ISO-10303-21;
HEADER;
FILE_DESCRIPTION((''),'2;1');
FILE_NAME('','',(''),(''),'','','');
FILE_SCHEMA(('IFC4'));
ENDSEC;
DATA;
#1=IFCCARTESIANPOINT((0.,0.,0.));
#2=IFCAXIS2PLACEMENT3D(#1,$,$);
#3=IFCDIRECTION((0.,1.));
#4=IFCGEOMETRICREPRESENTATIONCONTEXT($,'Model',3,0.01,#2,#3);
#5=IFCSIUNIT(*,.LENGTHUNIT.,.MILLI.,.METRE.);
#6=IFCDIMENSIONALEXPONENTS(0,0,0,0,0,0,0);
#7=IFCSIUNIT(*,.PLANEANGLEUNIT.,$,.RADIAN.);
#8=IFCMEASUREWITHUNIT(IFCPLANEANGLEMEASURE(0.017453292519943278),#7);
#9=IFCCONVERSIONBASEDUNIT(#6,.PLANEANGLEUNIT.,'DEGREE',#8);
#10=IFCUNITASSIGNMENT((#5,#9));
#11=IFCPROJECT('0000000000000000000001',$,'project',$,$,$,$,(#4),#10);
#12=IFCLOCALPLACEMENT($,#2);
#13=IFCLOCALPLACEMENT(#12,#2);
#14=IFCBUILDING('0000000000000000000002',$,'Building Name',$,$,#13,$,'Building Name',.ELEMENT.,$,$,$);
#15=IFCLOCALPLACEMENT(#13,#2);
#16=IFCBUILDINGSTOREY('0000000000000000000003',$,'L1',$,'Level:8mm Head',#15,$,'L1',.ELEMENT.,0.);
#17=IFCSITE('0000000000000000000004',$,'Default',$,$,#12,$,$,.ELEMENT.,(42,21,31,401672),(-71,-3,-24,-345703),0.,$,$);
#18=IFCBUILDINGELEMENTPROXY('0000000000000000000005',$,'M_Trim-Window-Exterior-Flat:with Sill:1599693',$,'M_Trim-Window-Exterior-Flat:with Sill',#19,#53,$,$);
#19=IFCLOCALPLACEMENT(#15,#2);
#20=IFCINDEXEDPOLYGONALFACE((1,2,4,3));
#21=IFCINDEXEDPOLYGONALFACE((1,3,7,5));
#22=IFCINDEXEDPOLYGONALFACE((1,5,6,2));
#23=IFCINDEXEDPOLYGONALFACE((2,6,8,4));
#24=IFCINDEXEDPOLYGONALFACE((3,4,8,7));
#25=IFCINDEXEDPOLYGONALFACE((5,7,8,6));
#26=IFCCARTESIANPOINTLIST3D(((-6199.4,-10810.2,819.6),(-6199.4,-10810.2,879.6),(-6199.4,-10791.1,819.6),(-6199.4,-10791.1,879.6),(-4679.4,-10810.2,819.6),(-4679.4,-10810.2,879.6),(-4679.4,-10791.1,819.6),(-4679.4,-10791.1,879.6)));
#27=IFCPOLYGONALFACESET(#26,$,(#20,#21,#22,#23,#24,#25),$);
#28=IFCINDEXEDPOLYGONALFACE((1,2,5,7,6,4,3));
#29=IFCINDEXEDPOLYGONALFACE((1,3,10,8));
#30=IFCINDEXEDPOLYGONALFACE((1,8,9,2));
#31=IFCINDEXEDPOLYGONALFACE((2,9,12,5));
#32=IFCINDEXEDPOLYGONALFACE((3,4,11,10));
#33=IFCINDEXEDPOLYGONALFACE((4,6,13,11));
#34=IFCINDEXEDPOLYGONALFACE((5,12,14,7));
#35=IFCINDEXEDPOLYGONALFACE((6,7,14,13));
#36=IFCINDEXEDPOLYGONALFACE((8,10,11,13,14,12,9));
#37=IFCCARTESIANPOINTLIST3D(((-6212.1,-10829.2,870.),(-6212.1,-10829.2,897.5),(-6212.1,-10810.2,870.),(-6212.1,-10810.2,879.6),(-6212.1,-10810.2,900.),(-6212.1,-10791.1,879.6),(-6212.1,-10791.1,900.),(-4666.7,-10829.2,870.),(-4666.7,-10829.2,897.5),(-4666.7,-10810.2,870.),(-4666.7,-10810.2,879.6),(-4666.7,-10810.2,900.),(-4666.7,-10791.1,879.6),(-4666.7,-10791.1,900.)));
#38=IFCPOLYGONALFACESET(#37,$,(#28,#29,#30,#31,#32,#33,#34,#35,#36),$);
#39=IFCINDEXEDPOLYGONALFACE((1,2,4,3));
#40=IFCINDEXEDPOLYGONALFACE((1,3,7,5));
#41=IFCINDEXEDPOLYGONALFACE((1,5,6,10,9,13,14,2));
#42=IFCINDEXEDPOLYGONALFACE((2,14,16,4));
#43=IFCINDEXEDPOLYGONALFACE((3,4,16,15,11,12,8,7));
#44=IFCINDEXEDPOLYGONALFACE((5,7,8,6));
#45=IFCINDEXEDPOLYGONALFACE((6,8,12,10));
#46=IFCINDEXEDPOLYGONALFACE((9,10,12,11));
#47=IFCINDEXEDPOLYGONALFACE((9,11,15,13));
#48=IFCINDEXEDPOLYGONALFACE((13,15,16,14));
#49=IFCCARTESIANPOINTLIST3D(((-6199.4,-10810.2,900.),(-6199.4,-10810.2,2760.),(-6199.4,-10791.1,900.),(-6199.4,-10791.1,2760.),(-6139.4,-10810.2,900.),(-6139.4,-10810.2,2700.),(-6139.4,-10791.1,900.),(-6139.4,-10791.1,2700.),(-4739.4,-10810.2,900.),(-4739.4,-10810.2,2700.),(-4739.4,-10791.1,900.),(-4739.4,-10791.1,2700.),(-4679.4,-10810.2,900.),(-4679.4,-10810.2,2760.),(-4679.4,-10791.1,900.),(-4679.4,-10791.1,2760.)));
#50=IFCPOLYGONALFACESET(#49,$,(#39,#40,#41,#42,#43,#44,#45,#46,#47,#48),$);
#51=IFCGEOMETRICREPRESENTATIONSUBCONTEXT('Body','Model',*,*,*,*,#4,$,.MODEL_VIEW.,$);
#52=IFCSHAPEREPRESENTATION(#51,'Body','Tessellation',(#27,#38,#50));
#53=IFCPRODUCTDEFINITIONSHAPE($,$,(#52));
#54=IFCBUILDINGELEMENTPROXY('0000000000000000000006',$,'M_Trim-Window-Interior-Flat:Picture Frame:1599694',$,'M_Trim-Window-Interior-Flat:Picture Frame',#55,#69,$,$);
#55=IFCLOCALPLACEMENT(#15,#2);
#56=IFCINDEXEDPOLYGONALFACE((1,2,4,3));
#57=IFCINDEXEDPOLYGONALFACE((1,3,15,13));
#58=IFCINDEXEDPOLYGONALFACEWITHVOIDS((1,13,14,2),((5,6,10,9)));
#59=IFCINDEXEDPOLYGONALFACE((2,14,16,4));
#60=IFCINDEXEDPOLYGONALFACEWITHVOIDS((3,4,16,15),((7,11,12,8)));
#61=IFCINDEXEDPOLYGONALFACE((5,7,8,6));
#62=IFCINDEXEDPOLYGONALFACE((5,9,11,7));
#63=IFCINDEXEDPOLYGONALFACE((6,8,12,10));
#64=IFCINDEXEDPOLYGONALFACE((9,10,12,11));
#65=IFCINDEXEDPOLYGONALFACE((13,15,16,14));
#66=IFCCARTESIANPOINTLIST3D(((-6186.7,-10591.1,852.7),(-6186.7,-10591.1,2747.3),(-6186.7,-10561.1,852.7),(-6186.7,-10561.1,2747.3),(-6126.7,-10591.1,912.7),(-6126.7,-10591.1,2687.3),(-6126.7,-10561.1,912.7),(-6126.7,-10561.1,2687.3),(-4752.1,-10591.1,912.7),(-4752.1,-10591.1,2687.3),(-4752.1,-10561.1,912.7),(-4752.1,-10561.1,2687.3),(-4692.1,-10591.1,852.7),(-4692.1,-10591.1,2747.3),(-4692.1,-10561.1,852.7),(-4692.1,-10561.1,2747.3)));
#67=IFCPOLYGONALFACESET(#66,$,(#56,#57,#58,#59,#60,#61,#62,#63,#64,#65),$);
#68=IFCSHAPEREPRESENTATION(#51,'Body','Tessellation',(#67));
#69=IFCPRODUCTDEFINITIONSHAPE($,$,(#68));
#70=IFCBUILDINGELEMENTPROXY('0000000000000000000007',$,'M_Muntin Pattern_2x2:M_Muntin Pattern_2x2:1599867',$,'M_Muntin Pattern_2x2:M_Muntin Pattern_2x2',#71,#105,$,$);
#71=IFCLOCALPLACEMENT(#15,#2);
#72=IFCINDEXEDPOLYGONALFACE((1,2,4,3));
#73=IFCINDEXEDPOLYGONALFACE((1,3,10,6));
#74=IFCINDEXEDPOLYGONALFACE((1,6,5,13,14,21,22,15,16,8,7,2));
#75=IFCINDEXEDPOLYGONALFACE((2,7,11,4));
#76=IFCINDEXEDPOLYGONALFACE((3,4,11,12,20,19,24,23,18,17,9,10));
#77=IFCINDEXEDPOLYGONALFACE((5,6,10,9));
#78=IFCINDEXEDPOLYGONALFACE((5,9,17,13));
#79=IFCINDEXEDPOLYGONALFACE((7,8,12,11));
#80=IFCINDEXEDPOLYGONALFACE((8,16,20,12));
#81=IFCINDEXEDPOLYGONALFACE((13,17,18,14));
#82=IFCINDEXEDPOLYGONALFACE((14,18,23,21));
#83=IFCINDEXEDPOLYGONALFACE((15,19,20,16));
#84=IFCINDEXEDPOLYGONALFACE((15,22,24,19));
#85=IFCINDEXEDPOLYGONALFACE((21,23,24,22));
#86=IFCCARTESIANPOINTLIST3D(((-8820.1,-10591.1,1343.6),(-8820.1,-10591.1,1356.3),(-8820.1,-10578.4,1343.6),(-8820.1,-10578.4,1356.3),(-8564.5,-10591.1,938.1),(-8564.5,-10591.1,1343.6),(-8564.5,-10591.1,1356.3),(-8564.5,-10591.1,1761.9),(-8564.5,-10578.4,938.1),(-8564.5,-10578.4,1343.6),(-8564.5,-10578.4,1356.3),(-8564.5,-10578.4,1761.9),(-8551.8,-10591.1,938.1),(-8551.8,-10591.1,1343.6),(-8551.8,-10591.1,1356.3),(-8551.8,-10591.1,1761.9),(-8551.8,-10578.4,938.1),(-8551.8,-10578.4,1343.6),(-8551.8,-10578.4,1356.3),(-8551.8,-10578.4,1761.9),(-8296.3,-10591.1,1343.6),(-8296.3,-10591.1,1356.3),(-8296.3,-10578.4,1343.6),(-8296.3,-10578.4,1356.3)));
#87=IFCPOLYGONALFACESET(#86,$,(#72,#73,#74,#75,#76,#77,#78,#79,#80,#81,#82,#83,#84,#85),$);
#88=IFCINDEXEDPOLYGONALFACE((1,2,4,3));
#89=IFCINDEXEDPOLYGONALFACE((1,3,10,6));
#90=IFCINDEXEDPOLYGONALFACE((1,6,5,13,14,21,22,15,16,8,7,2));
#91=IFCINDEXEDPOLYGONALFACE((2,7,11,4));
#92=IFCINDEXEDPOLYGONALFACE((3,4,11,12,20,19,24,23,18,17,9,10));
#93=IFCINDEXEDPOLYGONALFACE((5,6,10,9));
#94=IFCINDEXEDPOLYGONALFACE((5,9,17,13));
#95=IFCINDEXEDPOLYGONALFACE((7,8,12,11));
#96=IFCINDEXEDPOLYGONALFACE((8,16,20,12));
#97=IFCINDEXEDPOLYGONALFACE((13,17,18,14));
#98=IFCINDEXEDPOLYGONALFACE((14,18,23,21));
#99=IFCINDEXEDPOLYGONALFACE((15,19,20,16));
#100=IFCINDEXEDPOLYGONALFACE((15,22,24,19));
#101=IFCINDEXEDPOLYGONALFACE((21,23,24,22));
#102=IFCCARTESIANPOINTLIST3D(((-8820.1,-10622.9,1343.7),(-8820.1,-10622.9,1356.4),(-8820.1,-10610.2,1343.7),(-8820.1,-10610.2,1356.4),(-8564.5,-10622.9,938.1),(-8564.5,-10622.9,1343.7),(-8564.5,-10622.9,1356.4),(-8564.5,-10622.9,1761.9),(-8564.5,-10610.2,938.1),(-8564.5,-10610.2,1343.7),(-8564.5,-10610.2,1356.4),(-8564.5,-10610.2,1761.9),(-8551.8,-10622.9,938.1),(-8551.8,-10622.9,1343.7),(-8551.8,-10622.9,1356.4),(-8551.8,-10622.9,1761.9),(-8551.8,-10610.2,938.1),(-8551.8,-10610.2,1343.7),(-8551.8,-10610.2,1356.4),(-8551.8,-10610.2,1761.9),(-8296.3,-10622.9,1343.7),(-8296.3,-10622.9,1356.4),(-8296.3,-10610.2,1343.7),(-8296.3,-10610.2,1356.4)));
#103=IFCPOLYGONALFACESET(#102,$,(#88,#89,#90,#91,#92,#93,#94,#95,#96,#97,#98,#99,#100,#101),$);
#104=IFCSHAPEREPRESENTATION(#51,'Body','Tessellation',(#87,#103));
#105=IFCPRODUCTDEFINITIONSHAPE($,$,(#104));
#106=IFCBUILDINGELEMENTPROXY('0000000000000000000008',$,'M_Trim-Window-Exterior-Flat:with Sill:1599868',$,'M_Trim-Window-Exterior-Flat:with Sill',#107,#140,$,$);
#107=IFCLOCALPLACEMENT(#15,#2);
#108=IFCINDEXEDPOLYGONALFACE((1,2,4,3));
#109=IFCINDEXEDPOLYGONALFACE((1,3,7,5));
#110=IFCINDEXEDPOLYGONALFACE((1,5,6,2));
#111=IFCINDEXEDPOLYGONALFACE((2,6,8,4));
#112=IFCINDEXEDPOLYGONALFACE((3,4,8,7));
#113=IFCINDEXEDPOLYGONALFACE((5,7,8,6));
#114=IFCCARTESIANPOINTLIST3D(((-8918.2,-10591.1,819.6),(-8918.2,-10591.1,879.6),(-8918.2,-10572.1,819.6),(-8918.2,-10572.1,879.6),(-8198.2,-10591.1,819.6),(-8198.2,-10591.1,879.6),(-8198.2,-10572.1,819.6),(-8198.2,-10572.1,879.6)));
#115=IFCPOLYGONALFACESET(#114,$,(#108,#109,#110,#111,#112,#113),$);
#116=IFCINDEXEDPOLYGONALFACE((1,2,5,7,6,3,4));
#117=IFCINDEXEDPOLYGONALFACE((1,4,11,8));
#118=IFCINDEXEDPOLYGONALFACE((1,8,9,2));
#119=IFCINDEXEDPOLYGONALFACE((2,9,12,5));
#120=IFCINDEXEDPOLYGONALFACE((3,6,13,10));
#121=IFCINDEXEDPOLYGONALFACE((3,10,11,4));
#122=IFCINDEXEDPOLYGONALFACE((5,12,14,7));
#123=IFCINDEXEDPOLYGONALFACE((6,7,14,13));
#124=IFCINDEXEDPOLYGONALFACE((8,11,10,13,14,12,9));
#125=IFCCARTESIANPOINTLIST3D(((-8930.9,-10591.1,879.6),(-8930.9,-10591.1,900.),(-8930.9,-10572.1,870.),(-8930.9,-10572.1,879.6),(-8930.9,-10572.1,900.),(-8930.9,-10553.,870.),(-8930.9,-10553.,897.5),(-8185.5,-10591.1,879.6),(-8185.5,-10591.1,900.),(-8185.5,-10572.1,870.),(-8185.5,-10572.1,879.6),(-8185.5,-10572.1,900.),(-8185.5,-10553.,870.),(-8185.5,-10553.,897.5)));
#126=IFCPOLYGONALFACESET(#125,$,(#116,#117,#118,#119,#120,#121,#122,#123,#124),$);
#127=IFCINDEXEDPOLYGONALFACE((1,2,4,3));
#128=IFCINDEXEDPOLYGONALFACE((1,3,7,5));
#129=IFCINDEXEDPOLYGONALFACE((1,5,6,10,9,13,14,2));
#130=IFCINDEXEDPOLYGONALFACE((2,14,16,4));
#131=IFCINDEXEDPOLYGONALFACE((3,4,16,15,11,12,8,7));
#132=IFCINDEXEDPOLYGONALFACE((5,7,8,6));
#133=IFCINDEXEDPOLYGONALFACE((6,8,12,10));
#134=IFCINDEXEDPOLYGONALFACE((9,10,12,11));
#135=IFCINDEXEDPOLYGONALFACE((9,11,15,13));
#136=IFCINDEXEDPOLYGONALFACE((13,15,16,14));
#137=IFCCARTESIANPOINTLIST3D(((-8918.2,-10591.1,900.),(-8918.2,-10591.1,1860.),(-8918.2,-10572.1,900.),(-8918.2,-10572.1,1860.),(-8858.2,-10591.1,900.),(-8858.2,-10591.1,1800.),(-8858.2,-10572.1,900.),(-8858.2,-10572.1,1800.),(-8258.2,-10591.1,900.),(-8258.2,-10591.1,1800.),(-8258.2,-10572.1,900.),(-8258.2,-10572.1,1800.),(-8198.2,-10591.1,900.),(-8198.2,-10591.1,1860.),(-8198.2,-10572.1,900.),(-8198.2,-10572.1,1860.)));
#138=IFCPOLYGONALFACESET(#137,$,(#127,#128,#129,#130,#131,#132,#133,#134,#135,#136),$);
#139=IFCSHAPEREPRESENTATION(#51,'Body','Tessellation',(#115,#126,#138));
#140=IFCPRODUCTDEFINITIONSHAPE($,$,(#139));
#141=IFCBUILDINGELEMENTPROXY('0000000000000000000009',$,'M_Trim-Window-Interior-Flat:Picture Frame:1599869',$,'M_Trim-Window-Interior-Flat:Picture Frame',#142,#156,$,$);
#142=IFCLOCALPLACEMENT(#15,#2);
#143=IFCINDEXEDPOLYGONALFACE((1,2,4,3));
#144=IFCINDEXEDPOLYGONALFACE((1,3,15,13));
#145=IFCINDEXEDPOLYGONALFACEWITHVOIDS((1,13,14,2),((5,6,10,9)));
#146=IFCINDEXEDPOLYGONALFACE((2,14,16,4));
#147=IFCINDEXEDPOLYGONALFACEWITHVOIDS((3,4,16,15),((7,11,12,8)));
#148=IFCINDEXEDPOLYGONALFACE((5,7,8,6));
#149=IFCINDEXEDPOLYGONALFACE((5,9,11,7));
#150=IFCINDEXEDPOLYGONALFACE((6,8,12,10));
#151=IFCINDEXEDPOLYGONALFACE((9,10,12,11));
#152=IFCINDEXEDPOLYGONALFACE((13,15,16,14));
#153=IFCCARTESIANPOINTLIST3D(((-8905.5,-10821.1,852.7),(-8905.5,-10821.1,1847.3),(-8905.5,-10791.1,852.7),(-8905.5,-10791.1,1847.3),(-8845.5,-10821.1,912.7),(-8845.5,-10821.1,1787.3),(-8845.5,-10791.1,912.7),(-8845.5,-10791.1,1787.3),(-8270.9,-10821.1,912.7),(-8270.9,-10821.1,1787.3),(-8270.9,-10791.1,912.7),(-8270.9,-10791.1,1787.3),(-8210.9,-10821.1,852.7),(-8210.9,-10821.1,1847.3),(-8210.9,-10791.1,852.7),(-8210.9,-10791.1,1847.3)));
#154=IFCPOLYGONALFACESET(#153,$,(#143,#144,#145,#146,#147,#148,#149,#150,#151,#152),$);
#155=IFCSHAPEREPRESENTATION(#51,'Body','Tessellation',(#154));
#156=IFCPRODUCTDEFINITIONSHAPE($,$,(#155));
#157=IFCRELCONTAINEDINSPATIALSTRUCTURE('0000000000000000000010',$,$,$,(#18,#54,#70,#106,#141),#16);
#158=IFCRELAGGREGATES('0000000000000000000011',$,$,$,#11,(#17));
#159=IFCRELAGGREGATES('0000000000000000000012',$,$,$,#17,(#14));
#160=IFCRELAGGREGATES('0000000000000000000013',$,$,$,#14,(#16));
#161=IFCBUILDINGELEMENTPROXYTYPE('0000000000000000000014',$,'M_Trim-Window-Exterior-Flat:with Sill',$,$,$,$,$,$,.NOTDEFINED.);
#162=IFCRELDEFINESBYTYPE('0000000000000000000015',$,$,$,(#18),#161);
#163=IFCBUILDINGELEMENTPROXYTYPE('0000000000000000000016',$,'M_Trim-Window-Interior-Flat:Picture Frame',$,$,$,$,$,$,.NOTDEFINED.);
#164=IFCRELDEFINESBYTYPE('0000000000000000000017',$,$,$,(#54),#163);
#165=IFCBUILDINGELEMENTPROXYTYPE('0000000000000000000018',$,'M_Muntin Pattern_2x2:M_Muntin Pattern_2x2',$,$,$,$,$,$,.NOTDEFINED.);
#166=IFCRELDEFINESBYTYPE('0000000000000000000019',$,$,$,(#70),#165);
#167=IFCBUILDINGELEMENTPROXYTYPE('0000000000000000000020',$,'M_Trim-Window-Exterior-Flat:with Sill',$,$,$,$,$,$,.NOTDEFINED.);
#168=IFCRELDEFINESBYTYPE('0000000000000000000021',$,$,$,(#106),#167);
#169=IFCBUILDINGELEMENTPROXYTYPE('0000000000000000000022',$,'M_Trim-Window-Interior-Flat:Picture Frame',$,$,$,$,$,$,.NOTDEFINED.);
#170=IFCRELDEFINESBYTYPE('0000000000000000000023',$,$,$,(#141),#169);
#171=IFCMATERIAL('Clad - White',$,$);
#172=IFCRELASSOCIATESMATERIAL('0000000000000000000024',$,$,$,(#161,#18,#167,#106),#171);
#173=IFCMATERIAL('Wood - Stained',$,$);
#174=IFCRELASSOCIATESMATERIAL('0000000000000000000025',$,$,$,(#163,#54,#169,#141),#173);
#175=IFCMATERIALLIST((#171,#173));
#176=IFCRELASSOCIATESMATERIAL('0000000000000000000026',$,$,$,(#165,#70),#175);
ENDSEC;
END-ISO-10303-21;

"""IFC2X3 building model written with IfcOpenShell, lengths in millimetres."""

from ifc_helpers import new_model, entity, si_unit, converted_unit, direction, frame, frame_2d, origin, place, context, subcontext, project, spatial, polyline, rectangle, outline, extrude, source, transform, mapped, material, material_list, type_object, type_shapes, element, save


model = new_model("IFC2X3")

# Units and contexts
model_context = context("Model", 3, precision=0.01, world=origin(), true_north=direction((0.0, 1.0)))
body_context = subcontext(model_context, "Body", "Model", "MODEL_VIEW")
ifc_project = project(units=[si_unit("LENGTHUNIT", "METRE", prefix="MILLI"), converted_unit("PLANEANGLEUNIT", "DEGREE", entity("IfcPlaneAngleMeasure", 0.017453292519943278), si_unit("PLANEANGLEUNIT", "RADIAN"), dimensions=[0, 0, 0, 0, 0, 0, 0])], contexts=[model_context])

# Site, building, storey
site_placement = place(None, origin())
site = spatial("IfcSite", under=ifc_project, at=site_placement, Name="Default", CompositionType="ELEMENT", RefLatitude=(42, 21, 31, 401672), RefLongitude=(-71, -3, -24, -345703), RefElevation=0.0)
building_placement = place(site_placement, origin())
building = spatial("IfcBuilding", under=site, at=building_placement, Name="Building Name", LongName="Building Name", CompositionType="ELEMENT")
storey_placement = place(building_placement, origin())
storey = spatial("IfcBuildingStorey", under=building, at=storey_placement, Name="L1", ObjectType="Level:8mm Head", LongName="L1", CompositionType="ELEMENT", Elevation=0.0)

# Building element proxies
ifc_material_1 = material(Name="Clad - White")
ifc_material_2 = material(Name="Wood - Stained")
ifc_material_list = material_list([ifc_material_1, ifc_material_2])
building_element_proxy_type_1 = type_object("IfcBuildingElementProxyType", Name="M_Trim-Window-Exterior-Flat:with Sill", PredefinedType="NOTDEFINED", material=ifc_material_1)
shared_shape_1 = source(origin(), body_context, "Body", "SweptSolid", [
    extrude(rectangle(XDim=1520.0, YDim=60.0, at=frame_2d((0.0, 0.0), x_axis=(1.0, 0.0))), frame((0.0, -1850.4, 0.0), z_axis=(0.0, 0.0, 1.0), x_axis=(-1.0, 0.0, 0.0)), (0.0, 0.0, 1.0), 19.0),
    extrude(outline(polyline([(-19.0, -15.2), (0.0, -15.2), (0.0, -5.7), (19.0, -5.7), (19.0, 14.8), (0.0, 14.8), (-19.0, 12.3), (-19.0, -15.2)])), frame((-772.7, -1814.8, 19.0), z_axis=(1.0, 0.0, 0.0), x_axis=(0.0, 0.0, -1.0)), (0.0, 0.0, 1.0), 1545.4),
    extrude(outline(polyline([(-945.0, -760.0), (915.0, -760.0), (915.0, -700.0), (-885.0, -700.0), (-885.0, 700.0), (915.0, 700.0), (915.0, 760.0), (-945.0, 760.0), (-945.0, -760.0)])), frame((0.0, -885.0, 0.0), z_axis=(0.0, 0.0, 1.0), x_axis=(0.0, -1.0, 0.0)), (0.0, 0.0, 1.0), 19.0),
])
type_shapes(building_element_proxy_type_1, [shared_shape_1])
proxy_1_placement = place(storey_placement, frame((-5439.4, -10791.1, 2700.0), z_axis=(0.0, -1.0, 0.0), x_axis=(1.0, 0.0, 0.0)))
element("IfcBuildingElementProxy", 1, at=proxy_1_placement, inside=storey, type_object=building_element_proxy_type_1, material=ifc_material_1, Name="M_Trim-Window-Exterior-Flat:with Sill:1599693", ObjectType="M_Trim-Window-Exterior-Flat:with Sill", context=body_context, shape_type="MappedRepresentation", body=[
    mapped(shared_shape_1, transform((0.0, 0.0, 0.0), scale=1.0)),
])
building_element_proxy_type_2 = type_object("IfcBuildingElementProxyType", Name="M_Trim-Window-Interior-Flat:Picture Frame", PredefinedType="NOTDEFINED", material=ifc_material_2)
shared_shape_2 = source(origin(), body_context, "Body", "SweptSolid", [
    extrude(outline(polyline([(-747.3, -947.3), (747.3, -947.3), (747.3, 947.3), (-747.3, 947.3), (-747.3, -947.3)]), holes=[polyline([(-687.3, -887.3), (-687.3, 887.3), (687.3, 887.3), (687.3, -887.3), (-687.3, -887.3)])]), frame((0.0, -900.0, 0.0), z_axis=(0.0, 0.0, 1.0), x_axis=(-1.0, 0.0, 0.0)), (0.0, 0.0, 1.0), 30.0),
])
type_shapes(building_element_proxy_type_2, [shared_shape_2])
proxy_2_placement = place(storey_placement, frame((-5439.4, -10591.1, 2700.0), z_axis=(0.0, 1.0, 0.0), x_axis=(-1.0, 0.0, 0.0)))
element("IfcBuildingElementProxy", 2, at=proxy_2_placement, inside=storey, type_object=building_element_proxy_type_2, material=ifc_material_2, Name="M_Trim-Window-Interior-Flat:Picture Frame:1599694", ObjectType="M_Trim-Window-Interior-Flat:Picture Frame", context=body_context, shape_type="MappedRepresentation", body=[
    mapped(shared_shape_2, transform((0.0, 0.0, 0.0), scale=1.0)),
])
building_element_proxy_type_3 = type_object("IfcBuildingElementProxyType", Name="M_Muntin Pattern_2x2:M_Muntin Pattern_2x2", PredefinedType="NOTDEFINED", material=ifc_material_list)
shared_shape_3 = source(origin(), body_context, "Body", "SweptSolid", [
    extrude(outline(polyline([(6.4, -6.4), (411.9, -6.4), (411.9, 6.3), (6.4, 6.3), (6.4, 261.9), (-6.3, 261.9), (-6.3, 6.3), (-411.9, 6.3), (-411.9, -6.4), (-6.3, -6.4), (-6.3, -261.9), (6.4, -261.9), (6.4, -6.4)])), frame((0.0, -22.2, 411.9), z_axis=(0.0, 1.0, 0.0), x_axis=(0.0, 0.0, 1.0)), (0.0, 0.0, 1.0), 12.7),
    extrude(outline(polyline([(6.4, -6.4), (411.9, -6.4), (411.9, 6.3), (6.4, 6.3), (6.4, 261.9), (-6.3, 261.9), (-6.3, 6.3), (-411.9, 6.3), (-411.9, -6.4), (-6.3, -6.4), (-6.3, -261.9), (6.4, -261.9), (6.4, -6.4)])), frame((0.0, 9.5, 411.9), z_axis=(0.0, 1.0, 0.0), x_axis=(0.0, 0.0, 1.0)), (0.0, 0.0, 1.0), 12.7),
])
type_shapes(building_element_proxy_type_3, [shared_shape_3])
proxy_3_placement = place(storey_placement, frame((-8558.2, -10600.6, 938.1), z_axis=(0.0, 0.0, 1.0), x_axis=(-1.0, 0.0, 0.0)))
element("IfcBuildingElementProxy", 3, at=proxy_3_placement, inside=storey, type_object=building_element_proxy_type_3, material=ifc_material_list, Name="M_Muntin Pattern_2x2:M_Muntin Pattern_2x2:1599867", ObjectType="M_Muntin Pattern_2x2:M_Muntin Pattern_2x2", context=body_context, shape_type="MappedRepresentation", body=[
    mapped(shared_shape_3, transform((0.0, 0.0, 0.0), scale=1.0)),
])
building_element_proxy_type_4 = type_object("IfcBuildingElementProxyType", Name="M_Trim-Window-Exterior-Flat:with Sill", PredefinedType="NOTDEFINED", material=ifc_material_1)
shared_shape_4 = source(origin(), body_context, "Body", "SweptSolid", [
    extrude(rectangle(XDim=720.0, YDim=60.0, at=frame_2d((0.0, 0.0), x_axis=(1.0, 0.0))), frame((0.0, -950.4, 0.0), z_axis=(0.0, 0.0, 1.0), x_axis=(-1.0, 0.0, 0.0)), (0.0, 0.0, 1.0), 19.0),
    extrude(outline(polyline([(-19.0, -15.2), (0.0, -15.2), (0.0, -5.7), (19.0, -5.7), (19.0, 14.8), (0.0, 14.8), (-19.0, 12.3), (-19.0, -15.2)])), frame((-372.7, -914.8, 19.0), z_axis=(1.0, 0.0, 0.0), x_axis=(0.0, 0.0, -1.0)), (0.0, 0.0, 1.0), 745.4),
    extrude(outline(polyline([(-495.0, -360.0), (465.0, -360.0), (465.0, -300.0), (-435.0, -300.0), (-435.0, 300.0), (465.0, 300.0), (465.0, 360.0), (-495.0, 360.0), (-495.0, -360.0)])), frame((0.0, -435.0, 0.0), z_axis=(0.0, 0.0, 1.0), x_axis=(0.0, -1.0, 0.0)), (0.0, 0.0, 1.0), 19.0),
])
type_shapes(building_element_proxy_type_4, [shared_shape_4])
proxy_4_placement = place(storey_placement, frame((-8558.2, -10591.1, 1800.0), z_axis=(0.0, 1.0, 0.0), x_axis=(-1.0, 0.0, 0.0)))
element("IfcBuildingElementProxy", 4, at=proxy_4_placement, inside=storey, type_object=building_element_proxy_type_4, material=ifc_material_1, Name="M_Trim-Window-Exterior-Flat:with Sill:1599868", ObjectType="M_Trim-Window-Exterior-Flat:with Sill", context=body_context, shape_type="MappedRepresentation", body=[
    mapped(shared_shape_4, transform((0.0, 0.0, 0.0), scale=1.0)),
])
building_element_proxy_type_5 = type_object("IfcBuildingElementProxyType", Name="M_Trim-Window-Interior-Flat:Picture Frame", PredefinedType="NOTDEFINED", material=ifc_material_2)
shared_shape_5 = source(origin(), body_context, "Body", "SweptSolid", [
    extrude(outline(polyline([(-347.3, -497.3), (347.3, -497.3), (347.3, 497.3), (-347.3, 497.3), (-347.3, -497.3)]), holes=[polyline([(-287.3, -437.3), (-287.3, 437.3), (287.3, 437.3), (287.3, -437.3), (-287.3, -437.3)])]), frame((0.0, -450.0, 0.0), z_axis=(0.0, 0.0, 1.0), x_axis=(-1.0, 0.0, 0.0)), (0.0, 0.0, 1.0), 30.0),
])
type_shapes(building_element_proxy_type_5, [shared_shape_5])
proxy_5_placement = place(storey_placement, frame((-8558.2, -10791.1, 1800.0), z_axis=(0.0, -1.0, 0.0), x_axis=(1.0, 0.0, 0.0)))
element("IfcBuildingElementProxy", 5, at=proxy_5_placement, inside=storey, type_object=building_element_proxy_type_5, material=ifc_material_2, Name="M_Trim-Window-Interior-Flat:Picture Frame:1599869", ObjectType="M_Trim-Window-Interior-Flat:Picture Frame", context=body_context, shape_type="MappedRepresentation", body=[
    mapped(shared_shape_5, transform((0.0, 0.0, 0.0), scale=1.0)),
])

save(model, "model.ifc")
